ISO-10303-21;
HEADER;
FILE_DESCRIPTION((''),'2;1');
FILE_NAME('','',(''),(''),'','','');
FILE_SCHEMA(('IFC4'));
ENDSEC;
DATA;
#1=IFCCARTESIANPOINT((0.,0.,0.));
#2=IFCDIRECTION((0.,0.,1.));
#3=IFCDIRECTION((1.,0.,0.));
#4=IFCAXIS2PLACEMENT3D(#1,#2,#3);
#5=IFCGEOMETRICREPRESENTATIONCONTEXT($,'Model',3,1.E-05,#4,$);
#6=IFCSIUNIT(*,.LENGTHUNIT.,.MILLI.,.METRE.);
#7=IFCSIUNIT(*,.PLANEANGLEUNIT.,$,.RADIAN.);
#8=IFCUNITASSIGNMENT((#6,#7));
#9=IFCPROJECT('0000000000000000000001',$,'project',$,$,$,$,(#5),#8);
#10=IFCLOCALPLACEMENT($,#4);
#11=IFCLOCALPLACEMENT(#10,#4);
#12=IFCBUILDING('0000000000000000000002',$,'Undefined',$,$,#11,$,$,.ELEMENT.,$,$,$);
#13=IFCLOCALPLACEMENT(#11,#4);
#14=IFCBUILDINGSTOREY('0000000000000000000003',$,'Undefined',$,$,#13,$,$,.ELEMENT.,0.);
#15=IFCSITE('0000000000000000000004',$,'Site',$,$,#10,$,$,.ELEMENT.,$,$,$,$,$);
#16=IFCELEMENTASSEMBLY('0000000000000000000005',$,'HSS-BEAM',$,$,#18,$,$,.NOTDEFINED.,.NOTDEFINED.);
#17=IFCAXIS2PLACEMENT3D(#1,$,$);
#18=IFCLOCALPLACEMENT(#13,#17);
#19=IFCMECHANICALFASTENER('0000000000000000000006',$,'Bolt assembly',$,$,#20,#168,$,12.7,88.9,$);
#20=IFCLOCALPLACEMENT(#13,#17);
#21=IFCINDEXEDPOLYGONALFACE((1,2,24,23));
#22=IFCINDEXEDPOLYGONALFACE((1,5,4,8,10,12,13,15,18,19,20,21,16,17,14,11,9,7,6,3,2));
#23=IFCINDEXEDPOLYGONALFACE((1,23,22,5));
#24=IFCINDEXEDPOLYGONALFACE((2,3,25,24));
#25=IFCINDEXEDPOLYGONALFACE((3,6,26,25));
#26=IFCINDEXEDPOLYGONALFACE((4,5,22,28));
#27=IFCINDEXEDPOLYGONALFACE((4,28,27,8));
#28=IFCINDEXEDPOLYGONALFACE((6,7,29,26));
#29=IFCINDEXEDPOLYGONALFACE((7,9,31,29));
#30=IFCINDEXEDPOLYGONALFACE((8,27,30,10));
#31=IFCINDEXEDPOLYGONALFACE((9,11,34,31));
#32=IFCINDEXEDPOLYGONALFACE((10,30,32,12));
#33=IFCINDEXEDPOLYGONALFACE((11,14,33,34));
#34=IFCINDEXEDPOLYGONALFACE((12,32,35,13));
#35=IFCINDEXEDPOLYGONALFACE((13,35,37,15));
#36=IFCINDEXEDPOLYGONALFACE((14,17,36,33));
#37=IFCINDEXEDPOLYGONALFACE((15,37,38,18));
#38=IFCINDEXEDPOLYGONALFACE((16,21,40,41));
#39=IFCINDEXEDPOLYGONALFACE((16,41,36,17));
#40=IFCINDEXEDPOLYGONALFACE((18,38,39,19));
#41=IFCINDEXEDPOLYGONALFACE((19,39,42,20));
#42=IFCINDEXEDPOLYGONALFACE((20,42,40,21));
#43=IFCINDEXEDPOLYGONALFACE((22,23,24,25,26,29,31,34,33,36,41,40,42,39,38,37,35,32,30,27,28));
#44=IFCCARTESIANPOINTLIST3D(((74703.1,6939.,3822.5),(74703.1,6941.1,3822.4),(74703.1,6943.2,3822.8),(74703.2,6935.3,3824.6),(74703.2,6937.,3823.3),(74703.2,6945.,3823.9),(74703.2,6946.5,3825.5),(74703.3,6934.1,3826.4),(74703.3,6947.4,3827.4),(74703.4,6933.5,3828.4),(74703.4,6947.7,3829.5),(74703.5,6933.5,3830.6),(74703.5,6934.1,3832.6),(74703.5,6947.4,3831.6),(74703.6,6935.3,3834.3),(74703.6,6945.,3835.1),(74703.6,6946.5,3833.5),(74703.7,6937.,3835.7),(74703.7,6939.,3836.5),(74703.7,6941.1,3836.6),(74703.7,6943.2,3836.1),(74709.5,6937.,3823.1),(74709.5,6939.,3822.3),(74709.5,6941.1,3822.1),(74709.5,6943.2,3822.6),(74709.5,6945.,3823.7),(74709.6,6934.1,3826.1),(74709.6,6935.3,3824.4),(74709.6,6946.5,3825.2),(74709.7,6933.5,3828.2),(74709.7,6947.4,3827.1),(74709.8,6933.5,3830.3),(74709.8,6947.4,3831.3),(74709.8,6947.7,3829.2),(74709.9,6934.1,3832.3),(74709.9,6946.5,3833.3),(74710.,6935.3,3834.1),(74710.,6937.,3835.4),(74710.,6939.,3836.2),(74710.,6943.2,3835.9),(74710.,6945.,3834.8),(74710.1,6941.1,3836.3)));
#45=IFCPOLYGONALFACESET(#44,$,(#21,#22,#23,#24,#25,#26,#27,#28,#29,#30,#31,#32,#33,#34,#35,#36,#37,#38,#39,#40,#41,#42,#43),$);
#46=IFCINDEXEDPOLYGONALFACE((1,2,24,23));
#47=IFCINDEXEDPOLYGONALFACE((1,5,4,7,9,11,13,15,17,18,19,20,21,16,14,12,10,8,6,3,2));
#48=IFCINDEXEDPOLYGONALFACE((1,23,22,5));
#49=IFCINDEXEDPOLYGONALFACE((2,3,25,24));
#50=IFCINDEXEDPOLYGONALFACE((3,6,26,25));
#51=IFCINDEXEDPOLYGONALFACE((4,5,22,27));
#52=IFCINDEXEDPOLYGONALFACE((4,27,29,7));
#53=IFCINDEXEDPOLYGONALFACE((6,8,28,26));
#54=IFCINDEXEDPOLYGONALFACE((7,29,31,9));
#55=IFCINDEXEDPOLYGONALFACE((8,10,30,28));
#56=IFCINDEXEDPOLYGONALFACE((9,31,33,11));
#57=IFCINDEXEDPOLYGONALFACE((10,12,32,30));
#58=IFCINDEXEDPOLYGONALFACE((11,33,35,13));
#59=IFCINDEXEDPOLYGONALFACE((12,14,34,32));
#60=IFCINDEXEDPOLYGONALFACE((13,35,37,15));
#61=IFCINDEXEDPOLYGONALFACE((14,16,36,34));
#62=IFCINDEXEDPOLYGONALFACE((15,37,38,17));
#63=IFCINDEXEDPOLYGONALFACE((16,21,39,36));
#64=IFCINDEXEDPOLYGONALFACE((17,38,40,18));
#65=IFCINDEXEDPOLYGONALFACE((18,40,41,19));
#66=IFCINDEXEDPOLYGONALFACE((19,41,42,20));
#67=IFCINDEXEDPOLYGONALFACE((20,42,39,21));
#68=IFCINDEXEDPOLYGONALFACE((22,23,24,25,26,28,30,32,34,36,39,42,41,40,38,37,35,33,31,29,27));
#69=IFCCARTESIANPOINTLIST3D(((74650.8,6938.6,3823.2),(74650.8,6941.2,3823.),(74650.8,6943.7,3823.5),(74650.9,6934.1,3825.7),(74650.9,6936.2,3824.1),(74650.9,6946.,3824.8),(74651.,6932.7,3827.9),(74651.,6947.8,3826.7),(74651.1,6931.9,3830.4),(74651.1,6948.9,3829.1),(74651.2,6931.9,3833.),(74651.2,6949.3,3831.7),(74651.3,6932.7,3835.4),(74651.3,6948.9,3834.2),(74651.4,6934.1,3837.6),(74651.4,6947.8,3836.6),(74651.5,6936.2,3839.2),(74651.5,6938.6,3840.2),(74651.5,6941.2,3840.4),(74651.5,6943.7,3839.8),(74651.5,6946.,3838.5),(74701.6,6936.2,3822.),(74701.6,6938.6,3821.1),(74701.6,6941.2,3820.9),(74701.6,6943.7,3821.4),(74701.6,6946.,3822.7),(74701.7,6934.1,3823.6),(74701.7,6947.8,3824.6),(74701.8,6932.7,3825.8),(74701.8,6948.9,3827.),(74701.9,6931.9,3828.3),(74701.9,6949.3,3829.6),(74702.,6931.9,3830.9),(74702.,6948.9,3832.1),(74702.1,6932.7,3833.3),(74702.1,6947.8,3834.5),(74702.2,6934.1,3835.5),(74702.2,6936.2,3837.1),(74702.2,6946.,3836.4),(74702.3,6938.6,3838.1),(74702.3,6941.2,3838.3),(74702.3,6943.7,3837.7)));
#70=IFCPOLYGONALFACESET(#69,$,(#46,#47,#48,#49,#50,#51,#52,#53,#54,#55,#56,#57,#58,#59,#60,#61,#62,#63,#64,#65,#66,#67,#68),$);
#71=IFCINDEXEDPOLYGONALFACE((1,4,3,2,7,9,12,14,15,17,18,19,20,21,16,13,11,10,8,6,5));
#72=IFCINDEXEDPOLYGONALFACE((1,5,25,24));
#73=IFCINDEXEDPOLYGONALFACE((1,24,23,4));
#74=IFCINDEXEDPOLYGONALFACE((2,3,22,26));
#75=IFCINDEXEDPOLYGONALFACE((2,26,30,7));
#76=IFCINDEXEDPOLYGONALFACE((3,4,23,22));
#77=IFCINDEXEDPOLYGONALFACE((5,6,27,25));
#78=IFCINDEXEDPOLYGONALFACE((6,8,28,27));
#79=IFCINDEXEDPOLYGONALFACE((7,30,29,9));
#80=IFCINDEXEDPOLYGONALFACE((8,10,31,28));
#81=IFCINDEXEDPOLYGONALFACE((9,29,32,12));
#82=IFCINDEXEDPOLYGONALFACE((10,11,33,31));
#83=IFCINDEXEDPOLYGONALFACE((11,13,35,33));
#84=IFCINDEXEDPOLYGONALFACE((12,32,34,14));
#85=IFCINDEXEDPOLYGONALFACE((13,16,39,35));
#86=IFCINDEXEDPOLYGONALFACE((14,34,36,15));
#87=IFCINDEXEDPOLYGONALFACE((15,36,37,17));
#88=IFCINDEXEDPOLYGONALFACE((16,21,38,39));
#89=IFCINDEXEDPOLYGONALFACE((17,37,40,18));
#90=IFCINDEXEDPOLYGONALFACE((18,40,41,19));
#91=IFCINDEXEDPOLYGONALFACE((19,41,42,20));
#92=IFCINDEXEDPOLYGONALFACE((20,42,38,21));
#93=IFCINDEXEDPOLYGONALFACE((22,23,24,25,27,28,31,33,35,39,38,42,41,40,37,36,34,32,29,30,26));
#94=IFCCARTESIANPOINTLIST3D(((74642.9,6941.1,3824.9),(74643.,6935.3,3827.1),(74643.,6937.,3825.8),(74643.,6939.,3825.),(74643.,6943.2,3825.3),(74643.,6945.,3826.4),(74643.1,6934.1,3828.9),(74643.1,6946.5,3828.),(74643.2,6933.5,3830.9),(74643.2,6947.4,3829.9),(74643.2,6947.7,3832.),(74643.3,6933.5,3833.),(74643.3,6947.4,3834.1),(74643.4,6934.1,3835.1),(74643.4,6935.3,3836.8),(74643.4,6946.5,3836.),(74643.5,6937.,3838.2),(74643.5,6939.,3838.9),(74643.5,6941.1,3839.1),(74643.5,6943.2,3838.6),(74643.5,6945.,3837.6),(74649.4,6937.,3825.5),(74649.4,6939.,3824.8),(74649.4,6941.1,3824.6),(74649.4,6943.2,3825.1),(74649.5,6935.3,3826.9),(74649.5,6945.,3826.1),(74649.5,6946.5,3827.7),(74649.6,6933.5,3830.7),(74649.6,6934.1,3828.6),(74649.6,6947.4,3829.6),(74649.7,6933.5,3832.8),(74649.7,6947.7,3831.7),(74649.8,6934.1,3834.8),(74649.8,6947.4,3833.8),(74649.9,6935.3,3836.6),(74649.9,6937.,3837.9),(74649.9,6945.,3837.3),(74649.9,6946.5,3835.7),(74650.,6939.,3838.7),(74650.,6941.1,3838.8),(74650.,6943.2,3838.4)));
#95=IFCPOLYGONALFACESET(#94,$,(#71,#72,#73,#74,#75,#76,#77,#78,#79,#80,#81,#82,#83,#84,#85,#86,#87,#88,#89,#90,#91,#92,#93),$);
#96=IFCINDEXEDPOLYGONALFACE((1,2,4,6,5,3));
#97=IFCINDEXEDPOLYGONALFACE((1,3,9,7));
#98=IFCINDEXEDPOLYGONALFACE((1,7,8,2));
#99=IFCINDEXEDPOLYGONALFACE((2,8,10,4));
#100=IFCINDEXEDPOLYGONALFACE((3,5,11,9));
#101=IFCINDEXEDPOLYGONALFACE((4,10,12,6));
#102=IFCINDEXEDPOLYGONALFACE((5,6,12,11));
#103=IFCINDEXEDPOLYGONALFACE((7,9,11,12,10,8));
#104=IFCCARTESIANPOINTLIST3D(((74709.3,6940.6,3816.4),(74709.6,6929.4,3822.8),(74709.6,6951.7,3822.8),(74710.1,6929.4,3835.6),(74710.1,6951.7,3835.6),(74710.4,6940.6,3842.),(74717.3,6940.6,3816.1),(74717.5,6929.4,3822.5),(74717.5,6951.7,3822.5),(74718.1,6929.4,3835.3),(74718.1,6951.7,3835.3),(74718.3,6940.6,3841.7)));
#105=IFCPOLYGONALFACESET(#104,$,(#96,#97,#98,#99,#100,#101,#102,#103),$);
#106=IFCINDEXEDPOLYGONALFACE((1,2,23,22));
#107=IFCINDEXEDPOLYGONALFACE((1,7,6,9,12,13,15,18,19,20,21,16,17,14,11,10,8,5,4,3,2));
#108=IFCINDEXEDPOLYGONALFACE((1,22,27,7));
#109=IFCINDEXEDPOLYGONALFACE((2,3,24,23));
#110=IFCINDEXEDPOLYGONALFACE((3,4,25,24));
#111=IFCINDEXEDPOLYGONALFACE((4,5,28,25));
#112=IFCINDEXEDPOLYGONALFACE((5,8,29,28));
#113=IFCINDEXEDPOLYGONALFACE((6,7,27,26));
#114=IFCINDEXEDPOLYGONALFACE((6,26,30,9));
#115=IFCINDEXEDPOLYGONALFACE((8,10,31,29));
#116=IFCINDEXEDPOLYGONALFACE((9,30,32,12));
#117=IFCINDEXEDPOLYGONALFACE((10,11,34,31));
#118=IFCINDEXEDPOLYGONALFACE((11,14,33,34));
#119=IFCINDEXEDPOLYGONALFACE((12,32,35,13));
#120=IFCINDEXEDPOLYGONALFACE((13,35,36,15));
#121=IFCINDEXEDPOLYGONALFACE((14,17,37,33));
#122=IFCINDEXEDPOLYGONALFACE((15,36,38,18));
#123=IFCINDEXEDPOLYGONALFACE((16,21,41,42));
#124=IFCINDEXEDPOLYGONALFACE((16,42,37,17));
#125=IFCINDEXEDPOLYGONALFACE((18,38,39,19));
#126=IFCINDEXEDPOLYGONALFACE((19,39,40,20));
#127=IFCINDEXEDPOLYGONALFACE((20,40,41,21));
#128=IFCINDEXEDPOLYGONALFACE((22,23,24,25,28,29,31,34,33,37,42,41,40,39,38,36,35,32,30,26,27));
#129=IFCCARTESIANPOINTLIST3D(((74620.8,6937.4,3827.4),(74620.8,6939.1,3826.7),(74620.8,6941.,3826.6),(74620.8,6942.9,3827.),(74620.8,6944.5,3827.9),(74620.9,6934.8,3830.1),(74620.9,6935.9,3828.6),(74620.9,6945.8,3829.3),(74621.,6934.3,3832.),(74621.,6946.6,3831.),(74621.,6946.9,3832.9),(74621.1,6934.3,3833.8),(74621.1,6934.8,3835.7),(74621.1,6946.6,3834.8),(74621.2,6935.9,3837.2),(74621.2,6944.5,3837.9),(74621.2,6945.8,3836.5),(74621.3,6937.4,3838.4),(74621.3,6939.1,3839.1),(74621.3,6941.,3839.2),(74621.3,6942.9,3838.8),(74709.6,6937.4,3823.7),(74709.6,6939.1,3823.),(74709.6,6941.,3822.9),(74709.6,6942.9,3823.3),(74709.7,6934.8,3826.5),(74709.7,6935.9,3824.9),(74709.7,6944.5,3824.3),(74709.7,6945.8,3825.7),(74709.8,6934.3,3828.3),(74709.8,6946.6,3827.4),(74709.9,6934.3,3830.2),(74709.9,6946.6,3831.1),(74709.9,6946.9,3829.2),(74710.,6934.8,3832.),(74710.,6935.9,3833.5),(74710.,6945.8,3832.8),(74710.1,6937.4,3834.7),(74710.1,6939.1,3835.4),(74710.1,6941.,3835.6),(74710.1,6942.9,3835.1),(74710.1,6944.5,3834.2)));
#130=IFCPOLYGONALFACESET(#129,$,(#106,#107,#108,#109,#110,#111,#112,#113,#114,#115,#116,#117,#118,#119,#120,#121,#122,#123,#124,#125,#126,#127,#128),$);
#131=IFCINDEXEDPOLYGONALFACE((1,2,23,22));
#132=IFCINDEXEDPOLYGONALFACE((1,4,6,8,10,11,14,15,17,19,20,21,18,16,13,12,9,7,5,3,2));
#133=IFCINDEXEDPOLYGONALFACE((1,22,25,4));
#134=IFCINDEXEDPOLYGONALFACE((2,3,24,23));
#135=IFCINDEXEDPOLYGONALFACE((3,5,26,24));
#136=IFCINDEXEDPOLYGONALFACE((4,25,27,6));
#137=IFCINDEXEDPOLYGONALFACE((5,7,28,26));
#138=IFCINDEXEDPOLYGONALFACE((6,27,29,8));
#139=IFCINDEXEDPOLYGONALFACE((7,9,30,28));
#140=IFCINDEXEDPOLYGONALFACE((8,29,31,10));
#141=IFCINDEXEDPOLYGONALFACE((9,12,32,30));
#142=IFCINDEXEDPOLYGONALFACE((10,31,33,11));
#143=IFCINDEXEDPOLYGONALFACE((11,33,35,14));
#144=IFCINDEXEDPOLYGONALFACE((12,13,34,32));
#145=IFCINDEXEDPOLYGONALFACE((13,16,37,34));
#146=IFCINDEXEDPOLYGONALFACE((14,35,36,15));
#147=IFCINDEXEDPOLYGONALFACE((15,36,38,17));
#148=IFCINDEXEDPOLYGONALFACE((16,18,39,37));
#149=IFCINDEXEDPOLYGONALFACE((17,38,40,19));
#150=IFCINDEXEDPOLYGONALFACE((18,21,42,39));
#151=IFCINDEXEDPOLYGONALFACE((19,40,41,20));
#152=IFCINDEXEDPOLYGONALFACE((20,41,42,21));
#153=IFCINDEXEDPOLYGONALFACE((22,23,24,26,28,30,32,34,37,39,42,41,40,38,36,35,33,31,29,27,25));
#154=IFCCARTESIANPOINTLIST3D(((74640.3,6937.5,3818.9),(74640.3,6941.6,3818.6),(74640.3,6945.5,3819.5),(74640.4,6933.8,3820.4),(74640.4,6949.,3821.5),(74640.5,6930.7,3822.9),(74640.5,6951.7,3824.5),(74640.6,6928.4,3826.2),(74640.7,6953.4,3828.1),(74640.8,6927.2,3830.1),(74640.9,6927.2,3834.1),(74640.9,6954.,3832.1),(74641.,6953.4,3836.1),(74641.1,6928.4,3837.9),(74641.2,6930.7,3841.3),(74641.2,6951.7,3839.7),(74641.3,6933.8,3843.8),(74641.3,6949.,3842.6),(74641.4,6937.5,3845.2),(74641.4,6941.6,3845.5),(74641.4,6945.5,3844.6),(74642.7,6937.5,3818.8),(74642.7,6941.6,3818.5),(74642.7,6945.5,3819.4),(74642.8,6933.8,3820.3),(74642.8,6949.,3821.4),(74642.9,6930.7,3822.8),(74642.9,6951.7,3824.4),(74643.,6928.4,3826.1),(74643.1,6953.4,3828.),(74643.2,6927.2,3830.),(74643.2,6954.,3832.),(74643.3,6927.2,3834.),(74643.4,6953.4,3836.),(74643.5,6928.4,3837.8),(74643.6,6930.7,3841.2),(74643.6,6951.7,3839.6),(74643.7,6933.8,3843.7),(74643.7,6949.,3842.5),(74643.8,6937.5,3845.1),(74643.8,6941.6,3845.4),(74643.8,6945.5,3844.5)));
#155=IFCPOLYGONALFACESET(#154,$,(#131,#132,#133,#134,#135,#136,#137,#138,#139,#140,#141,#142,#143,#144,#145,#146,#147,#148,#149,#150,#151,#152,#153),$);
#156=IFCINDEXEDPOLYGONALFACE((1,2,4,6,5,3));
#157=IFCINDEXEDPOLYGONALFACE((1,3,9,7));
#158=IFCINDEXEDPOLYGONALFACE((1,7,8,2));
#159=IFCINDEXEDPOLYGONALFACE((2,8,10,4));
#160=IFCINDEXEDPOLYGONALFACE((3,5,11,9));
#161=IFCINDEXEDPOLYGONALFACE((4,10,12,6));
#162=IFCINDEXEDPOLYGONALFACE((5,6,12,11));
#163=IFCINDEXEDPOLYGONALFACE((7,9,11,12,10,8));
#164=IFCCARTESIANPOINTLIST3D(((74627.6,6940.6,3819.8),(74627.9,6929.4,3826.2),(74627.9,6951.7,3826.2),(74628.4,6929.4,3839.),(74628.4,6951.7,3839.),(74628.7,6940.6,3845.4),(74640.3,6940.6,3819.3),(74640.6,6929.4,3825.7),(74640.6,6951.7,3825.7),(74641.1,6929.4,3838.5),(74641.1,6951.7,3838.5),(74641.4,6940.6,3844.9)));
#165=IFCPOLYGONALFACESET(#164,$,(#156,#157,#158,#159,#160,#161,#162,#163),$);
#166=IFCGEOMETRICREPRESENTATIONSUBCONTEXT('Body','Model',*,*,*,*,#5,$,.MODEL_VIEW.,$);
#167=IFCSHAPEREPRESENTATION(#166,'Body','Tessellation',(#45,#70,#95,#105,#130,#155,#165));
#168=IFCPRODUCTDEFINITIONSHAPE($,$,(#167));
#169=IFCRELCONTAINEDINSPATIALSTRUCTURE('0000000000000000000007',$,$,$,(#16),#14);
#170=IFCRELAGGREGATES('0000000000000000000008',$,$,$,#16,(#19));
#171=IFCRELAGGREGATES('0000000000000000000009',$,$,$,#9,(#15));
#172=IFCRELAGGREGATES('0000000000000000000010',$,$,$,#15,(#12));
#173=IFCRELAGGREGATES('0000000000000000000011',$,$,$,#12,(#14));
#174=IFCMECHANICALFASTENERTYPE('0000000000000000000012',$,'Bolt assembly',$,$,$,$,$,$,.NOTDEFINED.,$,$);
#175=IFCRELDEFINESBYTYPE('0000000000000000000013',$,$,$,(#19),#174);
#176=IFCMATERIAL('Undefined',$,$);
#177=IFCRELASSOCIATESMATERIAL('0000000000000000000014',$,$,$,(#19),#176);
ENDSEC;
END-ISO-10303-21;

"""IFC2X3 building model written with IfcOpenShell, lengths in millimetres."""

from ifc_helpers import new_model, si_unit, frame, origin_with_axes, origin_2d_with_axis, place, context, subcontext, project, spatial, polyline, circle, outline, extrude, source, transform, mapped, material, type_object, element, aggregate, save


model = new_model("IFC2X3")

# Units and contexts
model_context = context("Model", 3, precision=1e-05, world=origin_with_axes())
body_context = subcontext(model_context, "Body", "Model", "MODEL_VIEW")
ifc_project = project(units=[si_unit("LENGTHUNIT", "METRE", prefix="MILLI"), si_unit("PLANEANGLEUNIT", "RADIAN")], contexts=[model_context])

# Site, building, storey
site_placement = place(None, origin_with_axes())
site = spatial("IfcSite", under=ifc_project, at=site_placement, Name="Site", CompositionType="ELEMENT")
building_placement = place(site_placement, origin_with_axes())
building = spatial("IfcBuilding", under=site, at=building_placement, Name="Undefined", CompositionType="ELEMENT")
storey_placement = place(building_placement, origin_with_axes())
storey = spatial("IfcBuildingStorey", under=building, at=storey_placement, Name="Undefined", CompositionType="ELEMENT", Elevation=0.0)

# Element assembly
assembly_1_placement = place(storey_placement, origin_with_axes())
assembly_1 = element("IfcElementAssembly", 1, at=assembly_1_placement, inside=storey, Name="HSS-BEAM", AssemblyPlace="NOTDEFINED", PredefinedType="NOTDEFINED")

# Shared definitions
ifc_material_1 = material(Name="Undefined")
mechanical_fastener_type = type_object("IfcMechanicalFastenerType", Name="Bolt assembly")

# Shared definitions
shared_shape_1 = source(origin_with_axes(), body_context, "Body", "SweptSolid", [
    extrude(circle(Radius=7.1, at=origin_2d_with_axis()), frame((0.0, -33.2, 0.0), z_axis=(0.0, 1.0, 0.0), x_axis=(1.0, 0.0, 0.0)), (0.0, 0.0, 1.0), 6.3),
    extrude(circle(Radius=8.7, at=origin_2d_with_axis()), frame((0.0, -25.4, 0.0), z_axis=(0.0, 1.0, 0.0), x_axis=(1.0, 0.0, 0.0)), (0.0, 0.0, 1.0), 50.8),
    extrude(circle(Radius=7.1, at=origin_2d_with_axis()), frame((0.0, 26.9, 0.0), z_axis=(0.0, 1.0, 0.0), x_axis=(1.0, 0.0, 0.0)), (0.0, 0.0, 1.0), 6.5),
    extrude(outline(polyline([(11.1, -6.4), (11.1, 6.4), (0.0, 12.8), (-11.1, 6.4), (-11.1, -6.4), (0.0, -12.8), (11.1, -6.4)])), frame((0.0, -41.3, 0.0), z_axis=(0.0, 1.0, 0.0), x_axis=(1.0, 0.0, 0.0)), (0.0, 0.0, 1.0), 7.9),
    extrude(circle(Radius=6.3, at=origin_2d_with_axis()), frame((0.0, -33.3, 0.0), z_axis=(0.0, 1.0, 0.0), x_axis=(1.0, 0.0, 0.0)), (0.0, 0.0, 1.0), 88.9),
    extrude(circle(Radius=13.5, at=origin_2d_with_axis()), frame((0.0, 33.3, 0.0), z_axis=(0.0, 1.0, 0.0), x_axis=(1.0, 0.0, 0.0)), (0.0, 0.0, 1.0), 2.4),
    extrude(outline(polyline([(11.1, -6.4), (11.1, 6.4), (0.0, 12.8), (-11.1, 6.4), (-11.1, -6.4), (0.0, -12.8), (11.1, -6.4)])), frame((0.0, 35.7, 0.0), z_axis=(0.0, 1.0, 0.0), x_axis=(1.0, 0.0, 0.0)), (0.0, 0.0, 1.0), 12.7),
])

# Mechanical fastener
mechanical_fastener_1_placement = place(assembly_1_placement, frame((74676.6, 6940.6, 3830.6), z_axis=(0.041337, 0.0, 0.999145), x_axis=(0.0, 1.0, 0.0)))
mechanical_fastener_1 = element("IfcMechanicalFastener", 2, at=mechanical_fastener_1_placement, type_object=mechanical_fastener_type, material=ifc_material_1, Name="Bolt assembly", NominalDiameter=12.7, NominalLength=88.9, context=body_context, shape_type="MappedRepresentation", body=[
    mapped(shared_shape_1, transform((0.0, 0.0, 0.0))),
])
aggregate(assembly_1, [mechanical_fastener_1])

save(model, "model.ifc")
